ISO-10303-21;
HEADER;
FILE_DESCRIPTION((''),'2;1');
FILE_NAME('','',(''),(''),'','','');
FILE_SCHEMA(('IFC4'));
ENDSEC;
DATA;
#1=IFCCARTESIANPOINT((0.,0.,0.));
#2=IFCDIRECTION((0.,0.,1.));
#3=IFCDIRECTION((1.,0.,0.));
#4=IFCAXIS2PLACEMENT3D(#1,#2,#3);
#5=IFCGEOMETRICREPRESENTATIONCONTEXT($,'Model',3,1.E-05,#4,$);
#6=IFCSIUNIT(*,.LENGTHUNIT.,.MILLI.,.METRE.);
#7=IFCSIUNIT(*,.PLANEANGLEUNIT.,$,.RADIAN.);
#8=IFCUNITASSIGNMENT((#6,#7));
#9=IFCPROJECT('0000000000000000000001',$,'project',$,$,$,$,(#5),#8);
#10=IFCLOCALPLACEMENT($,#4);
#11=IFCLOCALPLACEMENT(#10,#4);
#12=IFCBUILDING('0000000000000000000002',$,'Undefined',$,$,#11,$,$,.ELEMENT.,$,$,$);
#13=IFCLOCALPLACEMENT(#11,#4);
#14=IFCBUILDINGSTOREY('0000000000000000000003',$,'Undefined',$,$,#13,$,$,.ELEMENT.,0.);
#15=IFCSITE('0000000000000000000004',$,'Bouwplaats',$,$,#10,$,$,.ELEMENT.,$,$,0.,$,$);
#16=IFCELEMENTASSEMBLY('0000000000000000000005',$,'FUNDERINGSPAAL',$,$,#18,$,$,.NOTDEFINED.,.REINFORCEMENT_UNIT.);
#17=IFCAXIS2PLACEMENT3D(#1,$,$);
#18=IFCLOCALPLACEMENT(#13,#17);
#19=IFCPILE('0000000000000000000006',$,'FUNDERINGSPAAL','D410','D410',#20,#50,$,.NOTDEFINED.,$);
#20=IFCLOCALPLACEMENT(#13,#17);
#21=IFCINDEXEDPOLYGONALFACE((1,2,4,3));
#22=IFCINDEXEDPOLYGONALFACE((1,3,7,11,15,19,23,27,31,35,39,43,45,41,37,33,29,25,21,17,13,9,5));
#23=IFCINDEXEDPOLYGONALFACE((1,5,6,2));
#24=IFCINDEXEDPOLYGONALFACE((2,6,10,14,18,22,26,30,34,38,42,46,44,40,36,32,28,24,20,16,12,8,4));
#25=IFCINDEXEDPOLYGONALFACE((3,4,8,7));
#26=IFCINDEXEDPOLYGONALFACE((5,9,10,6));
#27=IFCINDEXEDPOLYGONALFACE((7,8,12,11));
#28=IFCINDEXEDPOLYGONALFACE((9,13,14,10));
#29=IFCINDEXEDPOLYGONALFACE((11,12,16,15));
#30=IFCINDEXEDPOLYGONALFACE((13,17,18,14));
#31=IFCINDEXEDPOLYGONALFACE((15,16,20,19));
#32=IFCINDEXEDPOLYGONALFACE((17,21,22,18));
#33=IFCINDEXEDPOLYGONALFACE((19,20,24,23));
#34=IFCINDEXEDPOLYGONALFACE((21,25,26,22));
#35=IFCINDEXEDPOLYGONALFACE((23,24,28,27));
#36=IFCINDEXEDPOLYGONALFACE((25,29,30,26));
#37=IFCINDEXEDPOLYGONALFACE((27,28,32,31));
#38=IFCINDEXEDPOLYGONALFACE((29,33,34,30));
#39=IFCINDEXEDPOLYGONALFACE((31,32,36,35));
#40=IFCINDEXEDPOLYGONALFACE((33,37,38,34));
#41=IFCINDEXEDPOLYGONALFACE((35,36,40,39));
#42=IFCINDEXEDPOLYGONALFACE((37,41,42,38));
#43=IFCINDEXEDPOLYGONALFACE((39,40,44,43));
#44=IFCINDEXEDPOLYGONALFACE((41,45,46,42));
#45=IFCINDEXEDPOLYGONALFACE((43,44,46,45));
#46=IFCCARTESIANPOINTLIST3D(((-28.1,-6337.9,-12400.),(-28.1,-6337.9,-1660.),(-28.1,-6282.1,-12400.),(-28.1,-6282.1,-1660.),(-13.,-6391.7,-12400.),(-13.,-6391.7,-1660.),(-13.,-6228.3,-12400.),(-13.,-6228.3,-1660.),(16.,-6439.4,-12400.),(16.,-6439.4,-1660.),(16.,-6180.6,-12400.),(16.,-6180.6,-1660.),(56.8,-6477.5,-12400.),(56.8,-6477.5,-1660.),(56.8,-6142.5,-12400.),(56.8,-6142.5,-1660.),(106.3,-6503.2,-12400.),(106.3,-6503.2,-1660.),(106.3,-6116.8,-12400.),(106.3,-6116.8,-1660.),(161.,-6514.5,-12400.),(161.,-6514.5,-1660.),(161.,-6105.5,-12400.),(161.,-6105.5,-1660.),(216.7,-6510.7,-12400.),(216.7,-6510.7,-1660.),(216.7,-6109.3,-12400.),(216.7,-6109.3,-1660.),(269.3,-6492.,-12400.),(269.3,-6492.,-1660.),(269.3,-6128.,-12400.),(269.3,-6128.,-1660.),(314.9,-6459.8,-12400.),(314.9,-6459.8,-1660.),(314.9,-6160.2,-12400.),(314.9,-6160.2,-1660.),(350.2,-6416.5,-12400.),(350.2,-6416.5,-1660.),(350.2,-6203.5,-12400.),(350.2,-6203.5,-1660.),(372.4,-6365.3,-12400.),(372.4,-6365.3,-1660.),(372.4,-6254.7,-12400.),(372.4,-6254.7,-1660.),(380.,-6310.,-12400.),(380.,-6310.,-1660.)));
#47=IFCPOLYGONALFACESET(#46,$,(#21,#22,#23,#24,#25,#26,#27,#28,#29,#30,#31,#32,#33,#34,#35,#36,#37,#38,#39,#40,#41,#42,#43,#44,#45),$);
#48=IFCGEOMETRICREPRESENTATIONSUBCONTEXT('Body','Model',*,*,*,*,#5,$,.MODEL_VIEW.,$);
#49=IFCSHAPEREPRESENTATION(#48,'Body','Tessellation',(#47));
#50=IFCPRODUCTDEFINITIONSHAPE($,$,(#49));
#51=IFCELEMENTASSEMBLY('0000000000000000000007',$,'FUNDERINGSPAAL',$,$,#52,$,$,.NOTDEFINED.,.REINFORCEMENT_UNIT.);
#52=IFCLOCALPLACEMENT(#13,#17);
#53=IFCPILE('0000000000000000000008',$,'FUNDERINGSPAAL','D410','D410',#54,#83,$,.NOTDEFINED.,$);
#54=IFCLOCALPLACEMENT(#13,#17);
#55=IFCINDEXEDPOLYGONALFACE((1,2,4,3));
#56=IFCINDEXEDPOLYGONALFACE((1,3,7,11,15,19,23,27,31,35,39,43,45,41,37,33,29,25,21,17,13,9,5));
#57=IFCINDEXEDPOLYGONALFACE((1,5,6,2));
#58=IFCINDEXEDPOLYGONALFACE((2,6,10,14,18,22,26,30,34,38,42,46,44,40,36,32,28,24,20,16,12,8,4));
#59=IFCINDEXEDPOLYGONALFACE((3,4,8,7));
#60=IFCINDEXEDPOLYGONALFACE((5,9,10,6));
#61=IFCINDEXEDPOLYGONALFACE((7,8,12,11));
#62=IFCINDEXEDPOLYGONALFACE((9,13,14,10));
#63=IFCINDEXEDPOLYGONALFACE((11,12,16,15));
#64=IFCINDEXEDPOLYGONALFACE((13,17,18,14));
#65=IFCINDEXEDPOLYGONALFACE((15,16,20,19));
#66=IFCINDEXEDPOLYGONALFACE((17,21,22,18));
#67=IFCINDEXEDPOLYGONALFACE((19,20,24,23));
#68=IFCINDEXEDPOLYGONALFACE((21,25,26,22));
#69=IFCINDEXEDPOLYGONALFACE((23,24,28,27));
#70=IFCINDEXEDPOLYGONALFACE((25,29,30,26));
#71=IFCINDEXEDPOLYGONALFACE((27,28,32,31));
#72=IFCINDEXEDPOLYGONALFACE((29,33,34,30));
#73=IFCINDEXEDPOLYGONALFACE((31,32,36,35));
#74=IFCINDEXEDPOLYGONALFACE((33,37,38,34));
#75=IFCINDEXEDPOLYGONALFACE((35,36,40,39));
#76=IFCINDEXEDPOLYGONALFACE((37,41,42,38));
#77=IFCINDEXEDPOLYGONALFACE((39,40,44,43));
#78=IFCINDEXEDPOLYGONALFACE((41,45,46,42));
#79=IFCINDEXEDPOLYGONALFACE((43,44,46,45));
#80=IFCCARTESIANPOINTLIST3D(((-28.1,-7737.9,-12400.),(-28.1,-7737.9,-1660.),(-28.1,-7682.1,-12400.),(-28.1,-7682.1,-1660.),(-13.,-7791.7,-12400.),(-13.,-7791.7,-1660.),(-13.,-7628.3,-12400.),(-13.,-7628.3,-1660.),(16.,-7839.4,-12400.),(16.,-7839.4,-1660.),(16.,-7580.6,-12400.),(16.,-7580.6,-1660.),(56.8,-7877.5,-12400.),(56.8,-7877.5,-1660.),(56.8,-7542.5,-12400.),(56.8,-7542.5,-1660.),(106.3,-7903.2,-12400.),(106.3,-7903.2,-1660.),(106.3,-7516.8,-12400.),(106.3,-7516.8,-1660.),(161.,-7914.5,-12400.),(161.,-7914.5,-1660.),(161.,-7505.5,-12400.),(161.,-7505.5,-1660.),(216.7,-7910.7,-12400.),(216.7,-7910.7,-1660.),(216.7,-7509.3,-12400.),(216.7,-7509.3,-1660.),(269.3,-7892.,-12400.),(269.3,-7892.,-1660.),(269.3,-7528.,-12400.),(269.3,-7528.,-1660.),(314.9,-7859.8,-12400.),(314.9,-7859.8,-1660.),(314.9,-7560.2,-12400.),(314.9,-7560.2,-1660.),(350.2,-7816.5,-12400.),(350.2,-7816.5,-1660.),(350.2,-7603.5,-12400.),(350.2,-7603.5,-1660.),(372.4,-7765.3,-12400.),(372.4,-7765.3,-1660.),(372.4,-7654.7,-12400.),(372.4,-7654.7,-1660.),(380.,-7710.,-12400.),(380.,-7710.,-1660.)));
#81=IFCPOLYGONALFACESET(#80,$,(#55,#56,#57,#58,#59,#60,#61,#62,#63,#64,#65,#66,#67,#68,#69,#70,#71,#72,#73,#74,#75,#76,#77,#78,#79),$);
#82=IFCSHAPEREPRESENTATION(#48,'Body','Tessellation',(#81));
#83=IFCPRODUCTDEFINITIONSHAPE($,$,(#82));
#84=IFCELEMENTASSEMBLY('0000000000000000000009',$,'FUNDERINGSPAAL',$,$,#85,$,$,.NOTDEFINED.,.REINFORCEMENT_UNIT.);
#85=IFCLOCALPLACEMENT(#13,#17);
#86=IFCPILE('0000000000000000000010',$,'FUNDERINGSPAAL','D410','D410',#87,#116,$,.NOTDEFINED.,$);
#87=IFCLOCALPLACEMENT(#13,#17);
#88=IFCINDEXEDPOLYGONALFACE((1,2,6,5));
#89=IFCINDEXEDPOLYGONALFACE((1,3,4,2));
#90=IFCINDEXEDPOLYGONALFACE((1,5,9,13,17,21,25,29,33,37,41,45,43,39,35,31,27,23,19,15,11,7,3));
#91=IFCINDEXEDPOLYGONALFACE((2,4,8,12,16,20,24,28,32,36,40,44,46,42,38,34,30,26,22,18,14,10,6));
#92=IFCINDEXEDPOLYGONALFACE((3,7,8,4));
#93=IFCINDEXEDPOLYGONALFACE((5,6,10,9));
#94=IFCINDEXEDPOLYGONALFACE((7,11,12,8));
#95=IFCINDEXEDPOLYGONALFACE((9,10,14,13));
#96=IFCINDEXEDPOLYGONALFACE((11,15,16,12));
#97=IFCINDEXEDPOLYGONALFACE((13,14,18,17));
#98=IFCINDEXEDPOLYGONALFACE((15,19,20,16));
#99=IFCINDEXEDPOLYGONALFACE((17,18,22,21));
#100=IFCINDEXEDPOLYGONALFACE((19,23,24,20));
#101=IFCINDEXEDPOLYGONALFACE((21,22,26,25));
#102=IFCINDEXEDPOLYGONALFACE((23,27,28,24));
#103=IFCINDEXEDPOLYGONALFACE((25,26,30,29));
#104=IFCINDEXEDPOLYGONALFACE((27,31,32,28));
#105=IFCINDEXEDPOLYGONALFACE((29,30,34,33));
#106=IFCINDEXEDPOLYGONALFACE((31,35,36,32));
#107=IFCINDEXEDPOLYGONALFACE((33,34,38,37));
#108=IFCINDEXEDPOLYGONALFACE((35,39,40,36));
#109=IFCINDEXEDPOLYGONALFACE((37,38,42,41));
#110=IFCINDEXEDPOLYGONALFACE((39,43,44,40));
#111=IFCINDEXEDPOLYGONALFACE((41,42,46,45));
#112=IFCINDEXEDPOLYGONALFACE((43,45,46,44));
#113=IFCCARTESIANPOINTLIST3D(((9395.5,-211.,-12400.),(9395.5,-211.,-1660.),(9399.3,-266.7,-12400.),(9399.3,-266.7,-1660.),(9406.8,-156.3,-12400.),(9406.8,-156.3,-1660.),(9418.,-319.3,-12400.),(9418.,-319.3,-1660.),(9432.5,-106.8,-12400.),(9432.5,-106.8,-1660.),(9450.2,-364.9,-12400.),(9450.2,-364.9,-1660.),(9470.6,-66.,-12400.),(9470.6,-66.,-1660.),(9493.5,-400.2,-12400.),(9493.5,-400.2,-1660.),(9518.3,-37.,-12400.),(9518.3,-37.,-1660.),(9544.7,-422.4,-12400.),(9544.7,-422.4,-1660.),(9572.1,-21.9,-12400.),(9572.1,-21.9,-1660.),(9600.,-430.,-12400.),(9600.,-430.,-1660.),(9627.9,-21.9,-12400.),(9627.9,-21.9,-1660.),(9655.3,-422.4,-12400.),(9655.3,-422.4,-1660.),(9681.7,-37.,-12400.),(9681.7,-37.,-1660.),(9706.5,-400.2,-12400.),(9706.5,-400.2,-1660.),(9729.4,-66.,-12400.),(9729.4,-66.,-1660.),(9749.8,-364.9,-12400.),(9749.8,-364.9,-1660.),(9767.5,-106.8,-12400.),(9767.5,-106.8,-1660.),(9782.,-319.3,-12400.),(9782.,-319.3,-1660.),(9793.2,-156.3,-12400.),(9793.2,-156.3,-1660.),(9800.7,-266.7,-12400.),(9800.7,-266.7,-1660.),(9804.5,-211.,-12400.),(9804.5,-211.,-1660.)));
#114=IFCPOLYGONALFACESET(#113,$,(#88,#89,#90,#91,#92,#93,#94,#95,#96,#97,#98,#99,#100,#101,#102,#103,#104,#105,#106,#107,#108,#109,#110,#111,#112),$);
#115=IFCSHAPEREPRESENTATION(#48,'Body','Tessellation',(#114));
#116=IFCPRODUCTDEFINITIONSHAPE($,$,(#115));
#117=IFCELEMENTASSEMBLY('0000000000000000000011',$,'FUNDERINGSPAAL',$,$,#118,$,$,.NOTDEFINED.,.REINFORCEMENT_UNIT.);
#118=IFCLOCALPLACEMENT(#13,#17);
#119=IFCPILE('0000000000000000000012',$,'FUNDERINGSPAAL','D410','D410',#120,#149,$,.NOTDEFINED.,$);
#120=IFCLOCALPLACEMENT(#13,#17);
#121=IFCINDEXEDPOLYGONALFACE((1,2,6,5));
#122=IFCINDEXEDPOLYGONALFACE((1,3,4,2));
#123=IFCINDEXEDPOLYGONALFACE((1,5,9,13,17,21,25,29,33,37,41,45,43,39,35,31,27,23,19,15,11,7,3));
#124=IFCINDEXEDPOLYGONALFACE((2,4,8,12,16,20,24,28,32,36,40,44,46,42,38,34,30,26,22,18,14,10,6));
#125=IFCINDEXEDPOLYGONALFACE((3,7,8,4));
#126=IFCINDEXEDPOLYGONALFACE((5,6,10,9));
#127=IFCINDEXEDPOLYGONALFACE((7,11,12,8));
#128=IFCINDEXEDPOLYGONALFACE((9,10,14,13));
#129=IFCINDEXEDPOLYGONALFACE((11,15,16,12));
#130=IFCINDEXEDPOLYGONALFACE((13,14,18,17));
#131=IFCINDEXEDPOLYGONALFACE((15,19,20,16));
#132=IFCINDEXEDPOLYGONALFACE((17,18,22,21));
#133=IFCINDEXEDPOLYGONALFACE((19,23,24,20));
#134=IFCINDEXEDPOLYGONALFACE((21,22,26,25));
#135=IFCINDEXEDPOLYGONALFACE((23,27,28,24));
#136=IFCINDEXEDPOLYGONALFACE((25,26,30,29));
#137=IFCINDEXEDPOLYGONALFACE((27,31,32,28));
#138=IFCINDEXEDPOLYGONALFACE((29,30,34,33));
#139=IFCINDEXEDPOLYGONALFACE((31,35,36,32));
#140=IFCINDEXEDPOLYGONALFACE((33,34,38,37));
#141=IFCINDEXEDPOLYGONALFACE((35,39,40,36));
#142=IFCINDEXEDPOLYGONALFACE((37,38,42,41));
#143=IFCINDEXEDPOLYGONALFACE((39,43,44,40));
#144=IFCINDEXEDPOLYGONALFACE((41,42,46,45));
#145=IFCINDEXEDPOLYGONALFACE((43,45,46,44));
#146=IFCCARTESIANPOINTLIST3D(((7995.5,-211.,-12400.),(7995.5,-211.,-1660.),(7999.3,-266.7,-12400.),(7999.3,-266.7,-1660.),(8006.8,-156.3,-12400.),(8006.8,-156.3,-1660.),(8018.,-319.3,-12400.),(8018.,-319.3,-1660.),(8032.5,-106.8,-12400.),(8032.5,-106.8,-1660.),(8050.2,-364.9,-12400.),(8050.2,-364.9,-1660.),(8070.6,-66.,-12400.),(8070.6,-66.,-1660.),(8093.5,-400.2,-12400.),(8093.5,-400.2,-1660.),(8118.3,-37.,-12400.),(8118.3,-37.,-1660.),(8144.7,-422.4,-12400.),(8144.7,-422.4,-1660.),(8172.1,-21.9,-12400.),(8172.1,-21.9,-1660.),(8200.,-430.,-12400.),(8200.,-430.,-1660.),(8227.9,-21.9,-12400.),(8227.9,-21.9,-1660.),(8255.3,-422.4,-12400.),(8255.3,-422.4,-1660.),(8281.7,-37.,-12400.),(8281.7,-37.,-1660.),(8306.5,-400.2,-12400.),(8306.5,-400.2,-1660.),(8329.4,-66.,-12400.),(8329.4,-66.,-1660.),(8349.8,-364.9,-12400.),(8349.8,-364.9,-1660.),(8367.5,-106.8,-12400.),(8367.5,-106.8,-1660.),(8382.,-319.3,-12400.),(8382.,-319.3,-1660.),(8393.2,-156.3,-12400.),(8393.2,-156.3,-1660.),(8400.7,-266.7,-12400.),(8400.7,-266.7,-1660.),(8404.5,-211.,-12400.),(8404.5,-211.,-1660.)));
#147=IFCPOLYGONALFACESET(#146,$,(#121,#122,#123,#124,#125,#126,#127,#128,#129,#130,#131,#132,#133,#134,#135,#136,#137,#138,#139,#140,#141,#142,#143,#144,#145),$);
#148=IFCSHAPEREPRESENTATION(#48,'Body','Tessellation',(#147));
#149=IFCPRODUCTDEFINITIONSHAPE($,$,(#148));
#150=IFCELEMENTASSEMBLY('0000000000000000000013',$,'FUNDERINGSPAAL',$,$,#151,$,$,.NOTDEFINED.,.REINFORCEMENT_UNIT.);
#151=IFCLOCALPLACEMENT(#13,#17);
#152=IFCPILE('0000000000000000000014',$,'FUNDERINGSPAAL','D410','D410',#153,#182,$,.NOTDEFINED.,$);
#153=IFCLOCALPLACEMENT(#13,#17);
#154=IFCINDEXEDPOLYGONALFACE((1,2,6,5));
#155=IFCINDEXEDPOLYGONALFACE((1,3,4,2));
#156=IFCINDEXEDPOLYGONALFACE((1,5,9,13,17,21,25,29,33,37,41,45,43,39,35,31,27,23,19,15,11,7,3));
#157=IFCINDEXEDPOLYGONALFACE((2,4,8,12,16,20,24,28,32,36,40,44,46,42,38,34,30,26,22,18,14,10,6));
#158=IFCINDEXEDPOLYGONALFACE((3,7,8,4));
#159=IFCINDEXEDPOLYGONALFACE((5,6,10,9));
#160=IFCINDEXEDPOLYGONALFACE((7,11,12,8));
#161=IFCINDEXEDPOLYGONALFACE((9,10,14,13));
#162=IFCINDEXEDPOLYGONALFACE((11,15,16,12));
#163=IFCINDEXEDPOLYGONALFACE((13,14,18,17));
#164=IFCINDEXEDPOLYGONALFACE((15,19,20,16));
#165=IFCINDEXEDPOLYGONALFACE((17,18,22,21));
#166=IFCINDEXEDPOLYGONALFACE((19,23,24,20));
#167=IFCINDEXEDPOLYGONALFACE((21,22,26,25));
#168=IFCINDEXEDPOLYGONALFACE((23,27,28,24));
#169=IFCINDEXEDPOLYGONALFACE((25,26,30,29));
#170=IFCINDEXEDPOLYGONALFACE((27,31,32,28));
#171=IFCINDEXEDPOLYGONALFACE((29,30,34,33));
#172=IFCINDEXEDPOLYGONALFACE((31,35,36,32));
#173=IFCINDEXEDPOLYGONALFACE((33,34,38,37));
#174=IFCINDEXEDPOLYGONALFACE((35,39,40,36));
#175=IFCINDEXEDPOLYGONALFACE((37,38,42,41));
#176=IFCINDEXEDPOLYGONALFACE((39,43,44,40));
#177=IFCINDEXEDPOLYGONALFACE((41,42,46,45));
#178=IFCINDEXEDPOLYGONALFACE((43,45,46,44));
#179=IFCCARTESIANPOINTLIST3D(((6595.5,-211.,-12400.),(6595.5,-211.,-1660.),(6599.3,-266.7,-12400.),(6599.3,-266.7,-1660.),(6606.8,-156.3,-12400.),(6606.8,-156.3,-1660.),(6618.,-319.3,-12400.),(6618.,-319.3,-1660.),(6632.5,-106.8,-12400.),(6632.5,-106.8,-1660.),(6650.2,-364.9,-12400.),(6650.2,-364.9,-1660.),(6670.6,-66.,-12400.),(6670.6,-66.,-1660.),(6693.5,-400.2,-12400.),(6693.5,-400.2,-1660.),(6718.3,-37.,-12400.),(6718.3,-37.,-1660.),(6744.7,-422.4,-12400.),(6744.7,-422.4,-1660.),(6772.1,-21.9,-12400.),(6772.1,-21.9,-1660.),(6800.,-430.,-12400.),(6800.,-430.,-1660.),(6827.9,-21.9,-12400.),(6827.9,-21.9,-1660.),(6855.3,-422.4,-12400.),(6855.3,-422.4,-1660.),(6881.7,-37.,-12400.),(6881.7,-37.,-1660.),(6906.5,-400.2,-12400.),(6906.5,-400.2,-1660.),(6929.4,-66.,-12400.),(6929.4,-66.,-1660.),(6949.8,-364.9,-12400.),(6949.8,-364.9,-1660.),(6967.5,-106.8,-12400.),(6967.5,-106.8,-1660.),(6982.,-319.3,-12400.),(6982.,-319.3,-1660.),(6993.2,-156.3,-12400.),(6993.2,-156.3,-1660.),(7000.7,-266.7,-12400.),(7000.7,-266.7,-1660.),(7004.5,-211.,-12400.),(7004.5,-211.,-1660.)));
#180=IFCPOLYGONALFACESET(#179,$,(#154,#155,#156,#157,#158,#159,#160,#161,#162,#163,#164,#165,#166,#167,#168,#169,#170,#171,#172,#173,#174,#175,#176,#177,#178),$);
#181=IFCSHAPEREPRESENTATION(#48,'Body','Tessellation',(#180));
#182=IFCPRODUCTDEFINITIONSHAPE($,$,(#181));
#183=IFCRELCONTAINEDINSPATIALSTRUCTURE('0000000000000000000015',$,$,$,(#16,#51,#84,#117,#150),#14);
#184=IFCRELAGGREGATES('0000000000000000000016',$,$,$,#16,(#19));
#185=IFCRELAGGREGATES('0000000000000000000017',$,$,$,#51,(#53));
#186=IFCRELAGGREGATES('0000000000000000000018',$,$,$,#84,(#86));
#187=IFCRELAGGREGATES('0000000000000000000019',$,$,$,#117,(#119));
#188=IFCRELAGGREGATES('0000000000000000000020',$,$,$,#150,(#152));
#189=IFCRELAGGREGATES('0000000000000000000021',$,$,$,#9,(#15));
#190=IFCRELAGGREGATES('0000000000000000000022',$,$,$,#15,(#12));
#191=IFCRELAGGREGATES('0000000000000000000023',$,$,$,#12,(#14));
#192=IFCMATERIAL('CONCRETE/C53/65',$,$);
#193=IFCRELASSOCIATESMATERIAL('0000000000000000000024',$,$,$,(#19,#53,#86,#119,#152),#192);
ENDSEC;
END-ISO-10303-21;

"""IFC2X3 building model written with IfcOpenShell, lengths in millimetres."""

from ifc_helpers import new_model, si_unit, frame, origin_with_axes, origin_2d_with_axis, place, context, subcontext, project, spatial, circle, extrude, clip, halfspace, material, element, aggregate, save


model = new_model("IFC2X3")

# Units and contexts
model_context = context("Model", 3, precision=1e-05, world=origin_with_axes())
body_context = subcontext(model_context, "Body", "Model", "MODEL_VIEW")
ifc_project = project(units=[si_unit("LENGTHUNIT", "METRE", prefix="MILLI"), si_unit("PLANEANGLEUNIT", "RADIAN")], contexts=[model_context])

# Site, building, storey
site_placement = place(None, origin_with_axes())
site = spatial("IfcSite", under=ifc_project, at=site_placement, Name="Bouwplaats", CompositionType="ELEMENT", RefElevation=0.0)
building_placement = place(site_placement, origin_with_axes())
building = spatial("IfcBuilding", under=site, at=building_placement, Name="Undefined", CompositionType="ELEMENT")
storey_placement = place(building_placement, origin_with_axes())
storey = spatial("IfcBuildingStorey", under=building, at=storey_placement, Name="Undefined", CompositionType="ELEMENT", Elevation=0.0)

# Element assemblies, piles
ifc_material_1 = material(Name="CONCRETE/C53/65")
assembly_1_placement = place(storey_placement, origin_with_axes())
assembly_1 = element("IfcElementAssembly", 1, at=assembly_1_placement, inside=storey, Name="FUNDERINGSPAAL", AssemblyPlace="NOTDEFINED", PredefinedType="REINFORCEMENT_UNIT")
pile_1_placement = place(assembly_1_placement, frame((175.0, -6310.0, -1660.0), z_axis=(0.0, 1.0, 0.0), x_axis=(0.0, 0.0, -1.0)))
pile_1 = element("IfcPile", 2, at=pile_1_placement, material=ifc_material_1, Name="FUNDERINGSPAAL", Description="D410", ObjectType="D410", PredefinedType="NOTDEFINED", context=body_context, shape_type="Clipping", body=[
    clip(extrude(circle(Radius=205.0, at=origin_2d_with_axis()), frame((10740.0, 0.0, 0.0), z_axis=(-1.0, 0.0, 0.0), x_axis=(0.0, -1.0, 0.0)), (0.0, 0.0, 1.0), 10740.0), halfspace(frame((0.0, 205.0, -205.0), z_axis=(-1.0, 0.0, 0.0), x_axis=(0.0, 0.0, 1.0)), False)),
])
aggregate(assembly_1, [pile_1])
assembly_2_placement = place(storey_placement, origin_with_axes())
assembly_2 = element("IfcElementAssembly", 3, at=assembly_2_placement, inside=storey, Name="FUNDERINGSPAAL", AssemblyPlace="NOTDEFINED", PredefinedType="REINFORCEMENT_UNIT")
pile_2_placement = place(assembly_2_placement, frame((175.0, -7710.0, -1660.0), z_axis=(0.0, 1.0, 0.0), x_axis=(0.0, 0.0, -1.0)))
pile_2 = element("IfcPile", 4, at=pile_2_placement, material=ifc_material_1, Name="FUNDERINGSPAAL", Description="D410", ObjectType="D410", PredefinedType="NOTDEFINED", context=body_context, shape_type="Clipping", body=[
    clip(extrude(circle(Radius=205.0, at=origin_2d_with_axis()), frame((10740.0, 0.0, 0.0), z_axis=(-1.0, 0.0, 0.0), x_axis=(0.0, -1.0, 0.0)), (0.0, 0.0, 1.0), 10740.0), halfspace(frame((0.0, 205.0, -205.0), z_axis=(-1.0, 0.0, 0.0), x_axis=(0.0, 0.0, 1.0)), False)),
])
aggregate(assembly_2, [pile_2])
assembly_3_placement = place(storey_placement, origin_with_axes())
assembly_3 = element("IfcElementAssembly", 5, at=assembly_3_placement, inside=storey, Name="FUNDERINGSPAAL", AssemblyPlace="NOTDEFINED", PredefinedType="REINFORCEMENT_UNIT")
pile_3_placement = place(assembly_3_placement, frame((9600.0, -225.0, -1660.0), z_axis=(1.0, 0.0, 0.0), x_axis=(0.0, 0.0, -1.0)))
pile_3 = element("IfcPile", 6, at=pile_3_placement, material=ifc_material_1, Name="FUNDERINGSPAAL", Description="D410", ObjectType="D410", PredefinedType="NOTDEFINED", context=body_context, shape_type="Clipping", body=[
    clip(extrude(circle(Radius=205.0, at=origin_2d_with_axis()), frame((10740.0, 0.0, 0.0), z_axis=(-1.0, 0.0, 0.0), x_axis=(0.0, -1.0, 0.0)), (0.0, 0.0, 1.0), 10740.0), halfspace(frame((0.0, 205.0, -205.0), z_axis=(-1.0, 0.0, 0.0), x_axis=(0.0, 0.0, 1.0)), False)),
])
aggregate(assembly_3, [pile_3])
assembly_4_placement = place(storey_placement, origin_with_axes())
assembly_4 = element("IfcElementAssembly", 7, at=assembly_4_placement, inside=storey, Name="FUNDERINGSPAAL", AssemblyPlace="NOTDEFINED", PredefinedType="REINFORCEMENT_UNIT")
pile_4_placement = place(assembly_4_placement, frame((8200.0, -225.0, -1660.0), z_axis=(1.0, 0.0, 0.0), x_axis=(0.0, 0.0, -1.0)))
pile_4 = element("IfcPile", 8, at=pile_4_placement, material=ifc_material_1, Name="FUNDERINGSPAAL", Description="D410", ObjectType="D410", PredefinedType="NOTDEFINED", context=body_context, shape_type="Clipping", body=[
    clip(extrude(circle(Radius=205.0, at=origin_2d_with_axis()), frame((10740.0, 0.0, 0.0), z_axis=(-1.0, 0.0, 0.0), x_axis=(0.0, -1.0, 0.0)), (0.0, 0.0, 1.0), 10740.0), halfspace(frame((0.0, 205.0, -205.0), z_axis=(-1.0, 0.0, 0.0), x_axis=(0.0, 0.0, 1.0)), False)),
])
aggregate(assembly_4, [pile_4])
assembly_5_placement = place(storey_placement, origin_with_axes())
assembly_5 = element("IfcElementAssembly", 9, at=assembly_5_placement, inside=storey, Name="FUNDERINGSPAAL", AssemblyPlace="NOTDEFINED", PredefinedType="REINFORCEMENT_UNIT")
pile_5_placement = place(assembly_5_placement, frame((6800.0, -225.0, -1660.0), z_axis=(1.0, 0.0, 0.0), x_axis=(0.0, 0.0, -1.0)))
pile_5 = element("IfcPile", 10, at=pile_5_placement, material=ifc_material_1, Name="FUNDERINGSPAAL", Description="D410", ObjectType="D410", PredefinedType="NOTDEFINED", context=body_context, shape_type="Clipping", body=[
    clip(extrude(circle(Radius=205.0, at=origin_2d_with_axis()), frame((10740.0, 0.0, 0.0), z_axis=(-1.0, 0.0, 0.0), x_axis=(0.0, -1.0, 0.0)), (0.0, 0.0, 1.0), 10740.0), halfspace(frame((0.0, 205.0, -205.0), z_axis=(-1.0, 0.0, 0.0), x_axis=(0.0, 0.0, 1.0)), False)),
])
aggregate(assembly_5, [pile_5])

save(model, "model.ifc")
